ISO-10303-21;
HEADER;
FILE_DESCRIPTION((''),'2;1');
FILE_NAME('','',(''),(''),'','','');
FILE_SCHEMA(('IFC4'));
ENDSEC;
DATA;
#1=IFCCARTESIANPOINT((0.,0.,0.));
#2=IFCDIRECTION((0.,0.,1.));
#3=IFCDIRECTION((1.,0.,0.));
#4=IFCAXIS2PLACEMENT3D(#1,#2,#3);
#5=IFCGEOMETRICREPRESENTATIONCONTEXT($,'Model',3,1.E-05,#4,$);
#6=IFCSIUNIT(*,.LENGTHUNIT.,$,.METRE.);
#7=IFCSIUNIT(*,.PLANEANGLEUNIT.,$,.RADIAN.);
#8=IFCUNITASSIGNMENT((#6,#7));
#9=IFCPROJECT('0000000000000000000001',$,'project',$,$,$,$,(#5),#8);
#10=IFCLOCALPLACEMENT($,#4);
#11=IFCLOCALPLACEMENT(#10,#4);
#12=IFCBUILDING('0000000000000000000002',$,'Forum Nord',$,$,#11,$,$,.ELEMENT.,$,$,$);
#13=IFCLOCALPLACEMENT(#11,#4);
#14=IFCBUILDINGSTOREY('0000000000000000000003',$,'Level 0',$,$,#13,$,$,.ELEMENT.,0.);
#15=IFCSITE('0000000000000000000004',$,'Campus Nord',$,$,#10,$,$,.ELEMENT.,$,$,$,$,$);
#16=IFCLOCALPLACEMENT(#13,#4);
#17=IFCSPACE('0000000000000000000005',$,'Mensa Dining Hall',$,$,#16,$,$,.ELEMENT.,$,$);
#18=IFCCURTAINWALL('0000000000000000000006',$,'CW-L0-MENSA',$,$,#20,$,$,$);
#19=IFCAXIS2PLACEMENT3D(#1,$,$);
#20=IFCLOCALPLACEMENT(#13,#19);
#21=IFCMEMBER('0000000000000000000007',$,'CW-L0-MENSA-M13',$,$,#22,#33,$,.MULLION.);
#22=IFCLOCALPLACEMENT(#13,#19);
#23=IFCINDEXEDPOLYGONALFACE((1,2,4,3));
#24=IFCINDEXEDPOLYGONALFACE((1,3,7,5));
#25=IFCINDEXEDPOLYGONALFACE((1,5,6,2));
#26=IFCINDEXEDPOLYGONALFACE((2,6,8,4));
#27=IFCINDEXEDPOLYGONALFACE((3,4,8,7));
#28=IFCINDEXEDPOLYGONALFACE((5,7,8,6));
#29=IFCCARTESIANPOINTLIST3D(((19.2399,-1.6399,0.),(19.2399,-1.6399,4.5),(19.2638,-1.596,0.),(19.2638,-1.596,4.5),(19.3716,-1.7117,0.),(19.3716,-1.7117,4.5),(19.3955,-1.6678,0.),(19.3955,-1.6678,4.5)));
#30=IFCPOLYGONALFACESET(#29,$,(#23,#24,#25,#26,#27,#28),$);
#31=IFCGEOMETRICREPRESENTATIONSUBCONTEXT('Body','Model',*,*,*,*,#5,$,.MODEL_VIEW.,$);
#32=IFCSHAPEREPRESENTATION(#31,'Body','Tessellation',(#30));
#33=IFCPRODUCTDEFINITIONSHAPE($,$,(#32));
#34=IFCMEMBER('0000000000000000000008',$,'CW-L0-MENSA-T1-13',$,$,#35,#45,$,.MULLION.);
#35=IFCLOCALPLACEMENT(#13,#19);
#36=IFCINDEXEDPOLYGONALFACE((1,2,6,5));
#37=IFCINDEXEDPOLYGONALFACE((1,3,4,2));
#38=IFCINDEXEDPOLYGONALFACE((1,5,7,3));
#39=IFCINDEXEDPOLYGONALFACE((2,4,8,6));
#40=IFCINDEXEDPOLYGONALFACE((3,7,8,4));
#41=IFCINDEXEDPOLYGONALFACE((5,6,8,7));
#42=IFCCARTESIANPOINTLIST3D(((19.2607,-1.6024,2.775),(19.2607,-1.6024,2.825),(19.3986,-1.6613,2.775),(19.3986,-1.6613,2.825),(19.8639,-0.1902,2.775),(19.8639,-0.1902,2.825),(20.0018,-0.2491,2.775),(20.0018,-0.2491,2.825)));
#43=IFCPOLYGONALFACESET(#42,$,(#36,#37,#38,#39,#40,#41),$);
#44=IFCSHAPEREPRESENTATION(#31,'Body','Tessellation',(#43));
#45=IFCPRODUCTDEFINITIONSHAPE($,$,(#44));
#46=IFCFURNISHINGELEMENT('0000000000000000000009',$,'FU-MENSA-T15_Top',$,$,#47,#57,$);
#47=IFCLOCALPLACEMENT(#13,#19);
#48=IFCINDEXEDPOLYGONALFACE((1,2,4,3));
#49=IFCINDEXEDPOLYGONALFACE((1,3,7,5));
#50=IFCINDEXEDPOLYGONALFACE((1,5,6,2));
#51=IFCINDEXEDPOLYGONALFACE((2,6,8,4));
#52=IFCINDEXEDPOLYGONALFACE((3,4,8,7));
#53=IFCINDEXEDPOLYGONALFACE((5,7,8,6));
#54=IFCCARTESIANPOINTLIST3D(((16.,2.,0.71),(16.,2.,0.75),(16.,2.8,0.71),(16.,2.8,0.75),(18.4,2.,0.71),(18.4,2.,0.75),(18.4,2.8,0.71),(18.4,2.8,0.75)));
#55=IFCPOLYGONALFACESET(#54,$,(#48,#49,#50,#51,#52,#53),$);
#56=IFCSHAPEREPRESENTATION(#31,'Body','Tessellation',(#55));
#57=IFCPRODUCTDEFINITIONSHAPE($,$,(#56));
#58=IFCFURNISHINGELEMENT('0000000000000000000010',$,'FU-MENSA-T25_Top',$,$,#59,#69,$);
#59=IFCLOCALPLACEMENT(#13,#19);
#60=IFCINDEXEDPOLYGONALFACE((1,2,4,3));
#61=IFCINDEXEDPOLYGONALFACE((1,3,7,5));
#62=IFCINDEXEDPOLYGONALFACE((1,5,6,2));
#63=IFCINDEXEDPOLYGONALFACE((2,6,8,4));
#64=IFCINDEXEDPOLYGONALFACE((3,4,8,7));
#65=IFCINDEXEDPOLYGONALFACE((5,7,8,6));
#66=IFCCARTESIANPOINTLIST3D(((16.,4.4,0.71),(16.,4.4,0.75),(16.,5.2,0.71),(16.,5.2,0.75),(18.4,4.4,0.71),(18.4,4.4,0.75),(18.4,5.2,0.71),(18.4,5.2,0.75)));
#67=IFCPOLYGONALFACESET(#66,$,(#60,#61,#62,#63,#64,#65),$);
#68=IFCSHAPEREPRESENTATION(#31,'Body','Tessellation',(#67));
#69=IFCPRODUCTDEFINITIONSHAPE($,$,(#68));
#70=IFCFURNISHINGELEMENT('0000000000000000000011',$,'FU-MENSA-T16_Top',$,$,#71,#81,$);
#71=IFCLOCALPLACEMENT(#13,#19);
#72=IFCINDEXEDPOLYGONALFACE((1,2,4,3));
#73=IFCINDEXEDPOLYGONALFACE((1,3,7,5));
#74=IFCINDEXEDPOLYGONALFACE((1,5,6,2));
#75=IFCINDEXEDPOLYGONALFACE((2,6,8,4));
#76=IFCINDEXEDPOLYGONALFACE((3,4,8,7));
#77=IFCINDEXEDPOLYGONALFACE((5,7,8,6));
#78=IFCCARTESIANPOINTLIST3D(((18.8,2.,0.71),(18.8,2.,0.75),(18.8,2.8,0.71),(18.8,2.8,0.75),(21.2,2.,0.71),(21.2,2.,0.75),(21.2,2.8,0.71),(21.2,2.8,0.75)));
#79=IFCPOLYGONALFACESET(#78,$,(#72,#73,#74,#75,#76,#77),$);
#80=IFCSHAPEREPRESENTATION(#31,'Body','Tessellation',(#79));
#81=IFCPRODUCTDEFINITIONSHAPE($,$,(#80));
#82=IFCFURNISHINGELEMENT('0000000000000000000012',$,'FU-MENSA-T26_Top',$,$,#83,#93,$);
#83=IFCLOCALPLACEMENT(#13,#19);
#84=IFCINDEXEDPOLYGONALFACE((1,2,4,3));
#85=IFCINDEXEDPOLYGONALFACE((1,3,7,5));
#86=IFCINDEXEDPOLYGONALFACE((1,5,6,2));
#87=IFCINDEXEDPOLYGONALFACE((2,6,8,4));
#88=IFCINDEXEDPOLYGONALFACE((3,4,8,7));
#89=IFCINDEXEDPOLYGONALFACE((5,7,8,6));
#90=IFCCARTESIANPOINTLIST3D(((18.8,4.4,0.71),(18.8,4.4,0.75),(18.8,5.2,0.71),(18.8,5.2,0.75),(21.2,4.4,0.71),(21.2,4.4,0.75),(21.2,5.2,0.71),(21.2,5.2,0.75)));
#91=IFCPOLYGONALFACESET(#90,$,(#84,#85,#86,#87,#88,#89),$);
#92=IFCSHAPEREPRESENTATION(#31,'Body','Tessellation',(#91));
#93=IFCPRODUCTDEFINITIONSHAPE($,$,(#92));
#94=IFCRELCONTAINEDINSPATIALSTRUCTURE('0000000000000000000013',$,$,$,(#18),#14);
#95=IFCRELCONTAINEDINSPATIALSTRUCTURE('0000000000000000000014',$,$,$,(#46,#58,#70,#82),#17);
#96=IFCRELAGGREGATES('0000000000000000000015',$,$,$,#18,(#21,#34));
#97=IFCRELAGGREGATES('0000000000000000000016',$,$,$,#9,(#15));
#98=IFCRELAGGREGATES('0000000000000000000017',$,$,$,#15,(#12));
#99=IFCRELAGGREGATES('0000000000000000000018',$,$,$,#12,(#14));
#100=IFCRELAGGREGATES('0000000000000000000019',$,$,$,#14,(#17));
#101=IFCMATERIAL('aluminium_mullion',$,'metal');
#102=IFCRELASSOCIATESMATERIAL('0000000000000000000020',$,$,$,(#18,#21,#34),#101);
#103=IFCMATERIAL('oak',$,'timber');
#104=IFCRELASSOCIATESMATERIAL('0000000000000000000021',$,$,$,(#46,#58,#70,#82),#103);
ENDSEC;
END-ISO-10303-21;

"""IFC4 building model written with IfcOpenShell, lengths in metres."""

from ifc_helpers import new_model, si_unit, frame, frame_2d, origin_with_axes, origin_2d_with_axis, place, context, subcontext, project, spatial, rectangle, extrude, material, element, aggregate, save


model = new_model("IFC4")

# Units and contexts
model_context = context("Model", 3, precision=1e-05, world=origin_with_axes())
body_context = subcontext(model_context, "Body", "Model", "MODEL_VIEW")
ifc_project = project(units=[si_unit("LENGTHUNIT", "METRE"), si_unit("PLANEANGLEUNIT", "RADIAN")], contexts=[model_context])

# Site, building, storey
site_placement = place(None, origin_with_axes())
site = spatial("IfcSite", under=ifc_project, at=site_placement, Name="Campus Nord", CompositionType="ELEMENT")
building_placement = place(site_placement, origin_with_axes())
building = spatial("IfcBuilding", under=site, at=building_placement, Name="Forum Nord", CompositionType="ELEMENT")
storey_placement = place(building_placement, origin_with_axes())
storey = spatial("IfcBuildingStorey", under=building, at=storey_placement, Name="Level 0", CompositionType="ELEMENT", Elevation=0.0)

# Curtain wall, members
ifc_material_1 = material(Name="aluminium_mullion", Category="metal")
curtain_wall_placement = place(storey_placement, origin_with_axes())
curtain_wall = element("IfcCurtainWall", 1, at=curtain_wall_placement, inside=storey, material=ifc_material_1, Name="CW-L0-MENSA")
member_1_placement = place(storey_placement, frame((19.3177, -1.6538, 0.0), z_axis=(0.0, 0.0, 1.0), x_axis=(0.47848, 0.8781, 0.0)))
member_1 = element("IfcMember", 2, at=member_1_placement, material=ifc_material_1, Name="CW-L0-MENSA-M13", PredefinedType="MULLION", context=body_context, shape_type="SweptSolid", body=[
    extrude(rectangle(XDim=0.05, YDim=0.15, at=origin_2d_with_axis()), origin_with_axes(), (0.0, 0.0, 1.0), 4.5),
])
member_2_placement = place(storey_placement, frame((19.3297, -1.6319, 2.8), z_axis=(0.39278, 0.91963, 0.0), x_axis=(-0.91963, 0.39278, 0.0)))
member_2 = element("IfcMember", 3, at=member_2_placement, material=ifc_material_1, Name="CW-L0-MENSA-T1-13", PredefinedType="MULLION", context=body_context, shape_type="SweptSolid", body=[
    extrude(rectangle(XDim=0.15, YDim=0.05, at=origin_2d_with_axis()), origin_with_axes(), (0.0, 0.0, 1.0), 1.5356),
])
aggregate(curtain_wall, [member_1, member_2])

# Shared definitions
space_placement = place(storey_placement, origin_with_axes())
space = spatial("IfcSpace", under=storey, at=space_placement, Name="Mensa Dining Hall", CompositionType="ELEMENT")

# Furnishing elements
ifc_material_2 = material(Name="oak", Category="timber")
furnishing_1_placement = place(storey_placement, frame((16.0, 2.0, 0.0), z_axis=(0.0, 0.0, 1.0), x_axis=(1.0, 0.0, 0.0)))
element("IfcFurnishingElement", 4, at=furnishing_1_placement, inside=space, material=ifc_material_2, Name="FU-MENSA-T15_Top", context=body_context, shape_type="SweptSolid", body=[
    extrude(rectangle(XDim=2.4, YDim=0.8, at=frame_2d((1.2, 0.4), x_axis=(1.0, 0.0))), frame((0.0, 0.0, 0.71), z_axis=(0.0, 0.0, 1.0), x_axis=(1.0, 0.0, 0.0)), (0.0, 0.0, 1.0), 0.04),
])
furnishing_2_placement = place(storey_placement, frame((16.0, 4.4, 0.0), z_axis=(0.0, 0.0, 1.0), x_axis=(1.0, 0.0, 0.0)))
element("IfcFurnishingElement", 5, at=furnishing_2_placement, inside=space, material=ifc_material_2, Name="FU-MENSA-T25_Top", context=body_context, shape_type="SweptSolid", body=[
    extrude(rectangle(XDim=2.4, YDim=0.8, at=frame_2d((1.2, 0.4), x_axis=(1.0, 0.0))), frame((0.0, 0.0, 0.71), z_axis=(0.0, 0.0, 1.0), x_axis=(1.0, 0.0, 0.0)), (0.0, 0.0, 1.0), 0.04),
])
furnishing_3_placement = place(storey_placement, frame((18.8, 2.0, 0.0), z_axis=(0.0, 0.0, 1.0), x_axis=(1.0, 0.0, 0.0)))
element("IfcFurnishingElement", 6, at=furnishing_3_placement, inside=space, material=ifc_material_2, Name="FU-MENSA-T16_Top", context=body_context, shape_type="SweptSolid", body=[
    extrude(rectangle(XDim=2.4, YDim=0.8, at=frame_2d((1.2, 0.4), x_axis=(1.0, 0.0))), frame((0.0, 0.0, 0.71), z_axis=(0.0, 0.0, 1.0), x_axis=(1.0, 0.0, 0.0)), (0.0, 0.0, 1.0), 0.04),
])
furnishing_4_placement = place(storey_placement, frame((18.8, 4.4, 0.0), z_axis=(0.0, 0.0, 1.0), x_axis=(1.0, 0.0, 0.0)))
element("IfcFurnishingElement", 7, at=furnishing_4_placement, inside=space, material=ifc_material_2, Name="FU-MENSA-T26_Top", context=body_context, shape_type="SweptSolid", body=[
    extrude(rectangle(XDim=2.4, YDim=0.8, at=frame_2d((1.2, 0.4), x_axis=(1.0, 0.0))), frame((0.0, 0.0, 0.71), z_axis=(0.0, 0.0, 1.0), x_axis=(1.0, 0.0, 0.0)), (0.0, 0.0, 1.0), 0.04),
])

save(model, "model.ifc")
